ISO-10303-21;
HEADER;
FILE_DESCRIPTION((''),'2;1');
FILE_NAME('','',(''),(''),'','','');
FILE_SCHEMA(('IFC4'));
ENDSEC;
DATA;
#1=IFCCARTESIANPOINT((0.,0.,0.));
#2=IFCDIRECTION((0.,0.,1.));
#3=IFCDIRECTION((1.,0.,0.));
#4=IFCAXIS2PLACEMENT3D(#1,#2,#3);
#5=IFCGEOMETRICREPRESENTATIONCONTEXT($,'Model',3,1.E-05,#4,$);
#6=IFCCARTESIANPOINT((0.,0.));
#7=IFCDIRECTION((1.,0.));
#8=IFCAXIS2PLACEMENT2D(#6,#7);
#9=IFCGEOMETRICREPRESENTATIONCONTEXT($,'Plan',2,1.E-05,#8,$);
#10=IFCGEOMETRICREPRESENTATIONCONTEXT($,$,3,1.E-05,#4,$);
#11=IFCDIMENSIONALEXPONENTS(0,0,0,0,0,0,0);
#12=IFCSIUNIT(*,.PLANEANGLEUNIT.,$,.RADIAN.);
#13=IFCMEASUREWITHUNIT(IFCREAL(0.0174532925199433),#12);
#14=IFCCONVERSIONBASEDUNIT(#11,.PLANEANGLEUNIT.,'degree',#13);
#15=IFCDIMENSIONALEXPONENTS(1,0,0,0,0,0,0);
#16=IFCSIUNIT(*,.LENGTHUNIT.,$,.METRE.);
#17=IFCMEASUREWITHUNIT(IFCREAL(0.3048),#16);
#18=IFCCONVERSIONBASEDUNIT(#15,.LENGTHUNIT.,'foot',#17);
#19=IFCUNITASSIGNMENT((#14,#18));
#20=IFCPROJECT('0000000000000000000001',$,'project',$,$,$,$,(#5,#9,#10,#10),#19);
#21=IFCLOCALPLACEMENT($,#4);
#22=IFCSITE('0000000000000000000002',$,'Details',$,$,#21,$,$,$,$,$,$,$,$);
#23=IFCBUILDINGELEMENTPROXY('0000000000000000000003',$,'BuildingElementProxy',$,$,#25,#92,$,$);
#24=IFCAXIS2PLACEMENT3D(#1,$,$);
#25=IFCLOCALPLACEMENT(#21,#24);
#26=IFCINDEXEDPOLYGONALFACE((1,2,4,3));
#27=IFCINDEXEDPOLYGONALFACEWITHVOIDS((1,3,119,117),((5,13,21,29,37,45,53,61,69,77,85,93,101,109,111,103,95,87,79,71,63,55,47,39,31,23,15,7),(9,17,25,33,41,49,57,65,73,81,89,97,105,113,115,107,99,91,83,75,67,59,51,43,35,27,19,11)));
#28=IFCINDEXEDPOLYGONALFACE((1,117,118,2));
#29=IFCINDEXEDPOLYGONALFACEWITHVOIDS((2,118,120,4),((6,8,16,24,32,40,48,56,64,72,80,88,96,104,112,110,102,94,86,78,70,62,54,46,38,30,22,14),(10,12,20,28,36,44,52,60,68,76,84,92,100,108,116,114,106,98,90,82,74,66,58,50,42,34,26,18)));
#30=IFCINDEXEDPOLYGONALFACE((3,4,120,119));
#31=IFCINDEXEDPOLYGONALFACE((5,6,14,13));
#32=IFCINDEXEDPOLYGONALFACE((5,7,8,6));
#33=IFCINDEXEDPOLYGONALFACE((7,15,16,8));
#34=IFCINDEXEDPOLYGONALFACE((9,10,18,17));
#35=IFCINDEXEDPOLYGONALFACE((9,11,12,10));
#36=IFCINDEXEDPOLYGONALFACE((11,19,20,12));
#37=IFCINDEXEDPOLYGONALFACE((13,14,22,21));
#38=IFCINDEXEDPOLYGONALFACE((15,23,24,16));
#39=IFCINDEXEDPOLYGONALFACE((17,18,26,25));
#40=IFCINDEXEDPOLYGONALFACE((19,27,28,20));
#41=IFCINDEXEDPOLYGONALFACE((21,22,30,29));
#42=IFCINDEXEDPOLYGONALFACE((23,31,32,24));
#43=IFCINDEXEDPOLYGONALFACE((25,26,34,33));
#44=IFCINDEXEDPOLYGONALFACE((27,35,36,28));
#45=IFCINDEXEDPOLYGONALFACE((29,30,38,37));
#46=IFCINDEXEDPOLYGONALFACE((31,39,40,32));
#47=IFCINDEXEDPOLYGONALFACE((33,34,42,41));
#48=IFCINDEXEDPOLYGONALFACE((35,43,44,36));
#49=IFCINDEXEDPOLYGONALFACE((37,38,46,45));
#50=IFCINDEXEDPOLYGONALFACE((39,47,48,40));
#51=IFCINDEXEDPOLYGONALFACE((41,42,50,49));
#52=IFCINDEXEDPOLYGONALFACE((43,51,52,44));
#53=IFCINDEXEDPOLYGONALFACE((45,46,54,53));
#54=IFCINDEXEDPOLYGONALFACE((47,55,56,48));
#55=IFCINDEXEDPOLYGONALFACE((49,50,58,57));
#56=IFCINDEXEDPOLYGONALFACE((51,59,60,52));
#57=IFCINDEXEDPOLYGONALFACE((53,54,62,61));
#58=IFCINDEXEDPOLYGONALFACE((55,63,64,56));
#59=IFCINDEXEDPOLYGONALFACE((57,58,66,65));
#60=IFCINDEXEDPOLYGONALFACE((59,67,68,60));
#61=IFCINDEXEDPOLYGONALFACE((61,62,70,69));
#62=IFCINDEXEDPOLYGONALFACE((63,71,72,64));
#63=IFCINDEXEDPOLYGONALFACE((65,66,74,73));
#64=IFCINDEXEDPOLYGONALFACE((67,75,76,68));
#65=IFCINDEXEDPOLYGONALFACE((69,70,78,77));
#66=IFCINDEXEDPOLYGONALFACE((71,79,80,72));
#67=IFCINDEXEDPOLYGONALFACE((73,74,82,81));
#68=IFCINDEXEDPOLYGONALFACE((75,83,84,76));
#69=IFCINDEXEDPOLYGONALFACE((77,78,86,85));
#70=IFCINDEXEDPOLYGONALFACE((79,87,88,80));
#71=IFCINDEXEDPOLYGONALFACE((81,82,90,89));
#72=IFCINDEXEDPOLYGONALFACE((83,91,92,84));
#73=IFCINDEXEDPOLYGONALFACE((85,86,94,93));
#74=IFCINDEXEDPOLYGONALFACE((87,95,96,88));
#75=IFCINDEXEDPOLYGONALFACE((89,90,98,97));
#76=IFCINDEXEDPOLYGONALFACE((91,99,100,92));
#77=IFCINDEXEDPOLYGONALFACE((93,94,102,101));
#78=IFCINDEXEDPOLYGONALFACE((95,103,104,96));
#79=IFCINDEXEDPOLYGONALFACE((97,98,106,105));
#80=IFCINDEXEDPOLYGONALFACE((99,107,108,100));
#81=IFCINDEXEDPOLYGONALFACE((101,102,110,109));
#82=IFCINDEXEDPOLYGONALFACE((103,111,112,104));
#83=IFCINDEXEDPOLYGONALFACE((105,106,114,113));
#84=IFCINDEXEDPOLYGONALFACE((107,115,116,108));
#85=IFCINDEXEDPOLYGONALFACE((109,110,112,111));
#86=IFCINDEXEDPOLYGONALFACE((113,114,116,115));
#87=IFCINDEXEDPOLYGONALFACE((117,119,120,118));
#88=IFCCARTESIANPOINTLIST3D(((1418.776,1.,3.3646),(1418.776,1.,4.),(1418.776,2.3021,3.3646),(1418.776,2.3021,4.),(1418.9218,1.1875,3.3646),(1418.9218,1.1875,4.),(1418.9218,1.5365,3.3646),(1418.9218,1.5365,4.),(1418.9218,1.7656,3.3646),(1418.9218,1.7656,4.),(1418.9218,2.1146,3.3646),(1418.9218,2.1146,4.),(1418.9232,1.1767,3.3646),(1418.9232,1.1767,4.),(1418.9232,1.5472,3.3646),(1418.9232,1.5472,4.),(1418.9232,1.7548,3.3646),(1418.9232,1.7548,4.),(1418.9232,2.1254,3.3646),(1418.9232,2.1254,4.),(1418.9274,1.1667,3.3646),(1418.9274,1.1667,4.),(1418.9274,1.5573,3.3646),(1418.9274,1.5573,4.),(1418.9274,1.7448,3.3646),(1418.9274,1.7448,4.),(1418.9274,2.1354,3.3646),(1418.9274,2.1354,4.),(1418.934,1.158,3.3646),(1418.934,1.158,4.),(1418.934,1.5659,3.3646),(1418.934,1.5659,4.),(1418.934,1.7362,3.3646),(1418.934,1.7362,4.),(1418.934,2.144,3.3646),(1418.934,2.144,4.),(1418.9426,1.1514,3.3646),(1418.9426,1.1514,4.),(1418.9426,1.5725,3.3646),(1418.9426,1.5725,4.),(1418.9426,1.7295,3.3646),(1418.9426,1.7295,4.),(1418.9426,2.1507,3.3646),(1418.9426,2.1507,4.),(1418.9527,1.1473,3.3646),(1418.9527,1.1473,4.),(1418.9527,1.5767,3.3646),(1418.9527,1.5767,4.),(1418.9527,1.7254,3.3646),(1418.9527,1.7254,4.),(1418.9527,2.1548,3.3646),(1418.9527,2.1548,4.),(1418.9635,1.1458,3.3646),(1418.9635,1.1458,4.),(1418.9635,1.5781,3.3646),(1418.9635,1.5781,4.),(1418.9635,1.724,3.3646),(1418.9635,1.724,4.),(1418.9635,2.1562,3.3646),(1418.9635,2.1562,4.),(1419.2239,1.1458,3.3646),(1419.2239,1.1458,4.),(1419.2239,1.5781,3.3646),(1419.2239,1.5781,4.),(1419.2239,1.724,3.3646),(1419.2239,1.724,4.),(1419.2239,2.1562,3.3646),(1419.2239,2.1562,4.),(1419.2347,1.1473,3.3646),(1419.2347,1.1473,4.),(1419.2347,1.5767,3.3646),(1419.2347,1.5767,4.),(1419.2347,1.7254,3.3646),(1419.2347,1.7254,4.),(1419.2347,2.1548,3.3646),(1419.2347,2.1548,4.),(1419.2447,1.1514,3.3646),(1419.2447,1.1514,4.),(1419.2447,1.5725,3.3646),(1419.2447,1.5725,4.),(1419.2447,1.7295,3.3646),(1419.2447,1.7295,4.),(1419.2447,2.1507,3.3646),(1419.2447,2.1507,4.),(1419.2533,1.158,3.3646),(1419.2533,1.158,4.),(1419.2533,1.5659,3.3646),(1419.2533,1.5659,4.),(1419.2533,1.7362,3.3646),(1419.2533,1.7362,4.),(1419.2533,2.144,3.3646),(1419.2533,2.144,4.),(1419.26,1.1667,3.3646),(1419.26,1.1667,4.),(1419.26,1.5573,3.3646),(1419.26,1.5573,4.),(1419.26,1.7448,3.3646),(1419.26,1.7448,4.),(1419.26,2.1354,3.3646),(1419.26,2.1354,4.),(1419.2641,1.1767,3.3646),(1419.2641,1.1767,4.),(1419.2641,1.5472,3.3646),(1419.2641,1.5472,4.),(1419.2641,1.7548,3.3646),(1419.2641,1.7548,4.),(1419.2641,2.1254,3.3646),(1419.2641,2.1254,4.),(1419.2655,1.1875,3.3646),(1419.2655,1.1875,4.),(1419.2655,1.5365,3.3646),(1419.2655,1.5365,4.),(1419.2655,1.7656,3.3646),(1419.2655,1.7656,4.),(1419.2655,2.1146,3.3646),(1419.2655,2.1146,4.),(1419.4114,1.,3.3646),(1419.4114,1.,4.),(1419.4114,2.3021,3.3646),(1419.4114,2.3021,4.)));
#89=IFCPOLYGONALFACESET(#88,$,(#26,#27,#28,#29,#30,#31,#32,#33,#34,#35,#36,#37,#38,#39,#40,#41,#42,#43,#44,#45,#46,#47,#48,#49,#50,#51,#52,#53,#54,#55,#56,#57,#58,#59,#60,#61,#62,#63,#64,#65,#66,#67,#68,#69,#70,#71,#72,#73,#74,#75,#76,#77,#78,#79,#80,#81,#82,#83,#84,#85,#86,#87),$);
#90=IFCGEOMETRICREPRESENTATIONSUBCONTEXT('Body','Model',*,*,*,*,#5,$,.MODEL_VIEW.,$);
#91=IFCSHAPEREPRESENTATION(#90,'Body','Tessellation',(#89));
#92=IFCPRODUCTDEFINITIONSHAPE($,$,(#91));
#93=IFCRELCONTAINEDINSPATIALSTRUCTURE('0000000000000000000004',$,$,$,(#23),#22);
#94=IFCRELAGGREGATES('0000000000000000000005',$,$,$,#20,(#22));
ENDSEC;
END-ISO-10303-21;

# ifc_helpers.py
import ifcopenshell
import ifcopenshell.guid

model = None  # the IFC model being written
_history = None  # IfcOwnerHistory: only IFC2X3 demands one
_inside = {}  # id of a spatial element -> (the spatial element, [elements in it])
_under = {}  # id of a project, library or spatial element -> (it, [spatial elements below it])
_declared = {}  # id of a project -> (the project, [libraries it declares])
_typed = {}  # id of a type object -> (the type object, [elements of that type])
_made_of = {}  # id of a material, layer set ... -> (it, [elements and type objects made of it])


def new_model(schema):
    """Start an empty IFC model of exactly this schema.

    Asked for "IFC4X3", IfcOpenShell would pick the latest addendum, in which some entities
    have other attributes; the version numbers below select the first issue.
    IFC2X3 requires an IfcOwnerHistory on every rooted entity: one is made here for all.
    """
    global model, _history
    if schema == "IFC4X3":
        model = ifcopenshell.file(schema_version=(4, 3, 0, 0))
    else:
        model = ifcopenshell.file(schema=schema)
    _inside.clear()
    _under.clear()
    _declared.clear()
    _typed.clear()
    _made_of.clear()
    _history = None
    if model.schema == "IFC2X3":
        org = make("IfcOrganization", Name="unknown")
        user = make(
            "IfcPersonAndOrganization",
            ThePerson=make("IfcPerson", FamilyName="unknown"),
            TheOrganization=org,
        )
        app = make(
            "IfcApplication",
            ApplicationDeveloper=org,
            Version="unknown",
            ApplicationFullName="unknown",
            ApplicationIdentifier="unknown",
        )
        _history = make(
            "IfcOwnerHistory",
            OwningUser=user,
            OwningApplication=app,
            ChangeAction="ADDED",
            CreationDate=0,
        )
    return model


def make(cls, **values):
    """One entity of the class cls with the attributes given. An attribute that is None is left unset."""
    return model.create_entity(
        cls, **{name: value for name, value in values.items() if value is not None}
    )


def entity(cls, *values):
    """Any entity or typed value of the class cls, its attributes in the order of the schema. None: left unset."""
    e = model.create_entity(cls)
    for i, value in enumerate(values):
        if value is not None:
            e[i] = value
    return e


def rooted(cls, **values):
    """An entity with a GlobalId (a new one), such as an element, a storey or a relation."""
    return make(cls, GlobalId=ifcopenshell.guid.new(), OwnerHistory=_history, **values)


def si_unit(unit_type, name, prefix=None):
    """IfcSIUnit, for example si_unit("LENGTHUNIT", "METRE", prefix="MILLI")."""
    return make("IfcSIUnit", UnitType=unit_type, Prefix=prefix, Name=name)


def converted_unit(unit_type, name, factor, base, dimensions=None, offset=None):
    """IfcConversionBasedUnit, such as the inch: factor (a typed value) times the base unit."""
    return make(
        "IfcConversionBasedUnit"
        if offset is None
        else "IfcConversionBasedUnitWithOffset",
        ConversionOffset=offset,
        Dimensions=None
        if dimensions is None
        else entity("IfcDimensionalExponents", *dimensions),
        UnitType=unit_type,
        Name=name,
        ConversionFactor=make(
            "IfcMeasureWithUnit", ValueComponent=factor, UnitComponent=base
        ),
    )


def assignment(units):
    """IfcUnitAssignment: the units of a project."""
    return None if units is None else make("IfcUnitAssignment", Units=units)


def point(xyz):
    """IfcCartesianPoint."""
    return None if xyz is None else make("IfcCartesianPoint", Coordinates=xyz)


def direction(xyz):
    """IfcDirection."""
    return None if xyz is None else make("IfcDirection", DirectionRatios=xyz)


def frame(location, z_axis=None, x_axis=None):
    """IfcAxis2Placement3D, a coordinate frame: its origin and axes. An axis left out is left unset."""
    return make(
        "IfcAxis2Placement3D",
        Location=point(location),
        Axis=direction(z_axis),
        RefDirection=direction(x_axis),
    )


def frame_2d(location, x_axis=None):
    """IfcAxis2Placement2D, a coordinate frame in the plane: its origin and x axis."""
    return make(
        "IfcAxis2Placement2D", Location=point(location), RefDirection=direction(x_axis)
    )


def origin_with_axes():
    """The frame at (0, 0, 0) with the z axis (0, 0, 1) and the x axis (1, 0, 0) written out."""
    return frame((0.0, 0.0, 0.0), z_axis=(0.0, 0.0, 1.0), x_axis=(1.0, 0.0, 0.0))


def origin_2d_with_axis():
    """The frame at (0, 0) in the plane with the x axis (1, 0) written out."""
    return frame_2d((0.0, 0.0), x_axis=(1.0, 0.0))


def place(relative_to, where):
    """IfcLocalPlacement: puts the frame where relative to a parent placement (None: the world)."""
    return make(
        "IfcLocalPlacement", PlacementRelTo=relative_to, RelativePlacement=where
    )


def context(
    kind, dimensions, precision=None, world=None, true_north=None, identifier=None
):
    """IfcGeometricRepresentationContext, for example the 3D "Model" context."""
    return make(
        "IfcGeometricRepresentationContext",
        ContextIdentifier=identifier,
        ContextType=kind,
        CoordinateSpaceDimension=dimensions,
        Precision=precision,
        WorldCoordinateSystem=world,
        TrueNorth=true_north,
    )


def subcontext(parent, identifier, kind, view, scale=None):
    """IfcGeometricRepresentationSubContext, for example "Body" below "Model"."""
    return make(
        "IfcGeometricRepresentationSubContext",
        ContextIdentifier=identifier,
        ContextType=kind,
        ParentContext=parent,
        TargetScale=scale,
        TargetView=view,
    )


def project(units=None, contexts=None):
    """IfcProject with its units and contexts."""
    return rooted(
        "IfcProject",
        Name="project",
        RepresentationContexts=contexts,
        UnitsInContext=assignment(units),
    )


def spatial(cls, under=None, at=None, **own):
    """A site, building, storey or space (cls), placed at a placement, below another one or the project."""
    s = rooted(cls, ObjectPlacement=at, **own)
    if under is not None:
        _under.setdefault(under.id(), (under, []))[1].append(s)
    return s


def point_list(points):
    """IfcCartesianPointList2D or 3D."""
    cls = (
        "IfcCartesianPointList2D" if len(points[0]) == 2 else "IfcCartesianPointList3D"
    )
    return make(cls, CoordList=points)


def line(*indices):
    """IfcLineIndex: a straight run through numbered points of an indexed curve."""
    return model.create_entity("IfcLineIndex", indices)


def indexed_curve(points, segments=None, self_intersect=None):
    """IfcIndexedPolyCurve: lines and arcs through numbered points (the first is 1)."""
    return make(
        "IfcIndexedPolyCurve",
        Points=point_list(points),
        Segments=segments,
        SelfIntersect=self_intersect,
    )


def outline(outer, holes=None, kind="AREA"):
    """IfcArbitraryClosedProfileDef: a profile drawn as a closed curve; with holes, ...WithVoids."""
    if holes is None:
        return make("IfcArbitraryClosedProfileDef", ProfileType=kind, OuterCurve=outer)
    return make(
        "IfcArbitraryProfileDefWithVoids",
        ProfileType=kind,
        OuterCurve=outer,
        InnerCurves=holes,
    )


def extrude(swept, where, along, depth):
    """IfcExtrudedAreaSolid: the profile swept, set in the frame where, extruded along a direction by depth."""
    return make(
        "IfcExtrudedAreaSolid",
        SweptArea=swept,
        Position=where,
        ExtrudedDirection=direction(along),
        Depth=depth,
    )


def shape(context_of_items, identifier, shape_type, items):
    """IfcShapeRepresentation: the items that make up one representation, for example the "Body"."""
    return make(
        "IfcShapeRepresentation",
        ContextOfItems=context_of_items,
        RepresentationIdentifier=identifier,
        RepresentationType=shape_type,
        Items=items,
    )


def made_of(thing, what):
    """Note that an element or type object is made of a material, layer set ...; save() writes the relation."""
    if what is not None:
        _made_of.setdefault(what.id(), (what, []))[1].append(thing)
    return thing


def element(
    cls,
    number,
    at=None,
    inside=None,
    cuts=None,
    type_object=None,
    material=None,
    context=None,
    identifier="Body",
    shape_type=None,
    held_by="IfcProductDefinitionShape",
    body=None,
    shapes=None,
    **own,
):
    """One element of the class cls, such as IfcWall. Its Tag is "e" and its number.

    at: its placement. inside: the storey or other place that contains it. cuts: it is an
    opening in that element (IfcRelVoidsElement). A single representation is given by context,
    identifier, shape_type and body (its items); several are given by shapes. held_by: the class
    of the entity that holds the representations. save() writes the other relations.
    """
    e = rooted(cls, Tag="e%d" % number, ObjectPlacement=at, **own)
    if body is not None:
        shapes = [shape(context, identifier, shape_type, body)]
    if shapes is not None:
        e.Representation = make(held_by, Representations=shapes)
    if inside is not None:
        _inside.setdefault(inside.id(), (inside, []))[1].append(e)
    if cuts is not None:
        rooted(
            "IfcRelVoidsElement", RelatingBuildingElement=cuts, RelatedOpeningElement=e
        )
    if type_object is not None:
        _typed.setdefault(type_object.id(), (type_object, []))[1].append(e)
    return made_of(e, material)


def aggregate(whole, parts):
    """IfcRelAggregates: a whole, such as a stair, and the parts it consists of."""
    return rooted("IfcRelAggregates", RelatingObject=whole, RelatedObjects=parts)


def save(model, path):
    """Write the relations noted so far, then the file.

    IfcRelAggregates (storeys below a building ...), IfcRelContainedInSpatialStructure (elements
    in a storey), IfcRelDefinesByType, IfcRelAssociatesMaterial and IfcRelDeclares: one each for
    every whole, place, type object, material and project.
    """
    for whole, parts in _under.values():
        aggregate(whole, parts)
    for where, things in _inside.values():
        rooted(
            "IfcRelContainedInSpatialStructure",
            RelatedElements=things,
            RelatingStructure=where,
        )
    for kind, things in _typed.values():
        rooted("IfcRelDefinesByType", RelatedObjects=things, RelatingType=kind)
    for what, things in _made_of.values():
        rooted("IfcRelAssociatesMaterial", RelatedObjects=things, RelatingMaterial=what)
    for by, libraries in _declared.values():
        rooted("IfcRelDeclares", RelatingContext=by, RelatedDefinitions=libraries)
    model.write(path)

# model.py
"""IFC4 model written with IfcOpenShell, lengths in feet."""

from ifc_helpers import new_model, entity, si_unit, converted_unit, frame, origin_with_axes, origin_2d_with_axis, place, context, subcontext, project, spatial, line, indexed_curve, outline, extrude, element, save


model = new_model("IFC4")

# Units and contexts
model_context = context("Model", 3, precision=1e-05, world=origin_with_axes())
plan_context = context("Plan", 2, precision=1e-05, world=origin_2d_with_axis())
context_of_model = context(None, 3, precision=1e-05, world=origin_with_axes())
body_context = subcontext(model_context, "Body", "Model", "MODEL_VIEW")
ifc_project = project(units=[converted_unit("PLANEANGLEUNIT", "degree", entity("IfcReal", 0.0174532925199433), si_unit("PLANEANGLEUNIT", "RADIAN"), dimensions=[0, 0, 0, 0, 0, 0, 0]), converted_unit("LENGTHUNIT", "foot", entity("IfcReal", 0.3048), si_unit("LENGTHUNIT", "METRE"), dimensions=[1, 0, 0, 0, 0, 0, 0])], contexts=[model_context, plan_context, context_of_model, context_of_model])

# Site
site_placement = place(None, origin_with_axes())
site = spatial("IfcSite", under=ifc_project, at=site_placement, Name="Details")

# Building element proxy
proxy_1_placement = place(site_placement, frame((1419.0936, 2.3021, 3.3646), z_axis=(0.0, 0.0, 1.0), x_axis=(0.0, 1.0, 0.0)))
element("IfcBuildingElementProxy", 1, at=proxy_1_placement, inside=site, Name="BuildingElementProxy", context=body_context, shape_type="SweptSolid", body=[
    extrude(outline(indexed_curve([(-0.3177, -0.651), (0.3177, -0.651), (0.3177, 0.651), (-0.3177, 0.651), (0.1719, -0.1146), (0.1719, -0.4635), (0.1705, -0.4743), (0.1663, -0.4844), (0.1597, -0.493), (0.151, -0.4996), (0.141, -0.5038), (0.1302, -0.5052), (-0.1302, -0.5052), (-0.141, -0.5038), (-0.151, -0.4996), (-0.1597, -0.493), (-0.1663, -0.4844), (-0.1705, -0.4743), (-0.1719, -0.4635), (-0.1719, -0.1146), (-0.1705, -0.1038), (-0.1663, -0.0938), (-0.1597, -0.0851), (-0.151, -0.0785), (-0.141, -0.0743), (-0.1302, -0.0729), (0.1302, -0.0729), (0.141, -0.0743), (0.151, -0.0785), (0.1597, -0.0851), (0.1663, -0.0938), (0.1705, -0.1038), (0.151, 0.0785), (0.141, 0.0743), (0.1302, 0.0729), (-0.1302, 0.0729), (-0.141, 0.0743), (-0.151, 0.0785), (-0.1597, 0.0851), (-0.1663, 0.0937), (-0.1705, 0.1038), (-0.1719, 0.1146), (-0.1719, 0.4635), (-0.1705, 0.4743), (-0.1663, 0.4844), (-0.1597, 0.493), (-0.151, 0.4996), (-0.141, 0.5038), (-0.1302, 0.5052), (0.1302, 0.5052), (0.141, 0.5038), (0.151, 0.4996), (0.1597, 0.493), (0.1663, 0.4844), (0.1705, 0.4743), (0.1719, 0.4635), (0.1719, 0.1146), (0.1705, 0.1038), (0.1663, 0.0937), (0.1597, 0.0851)], segments=[line(4, 3), line(3, 2), line(2, 1), line(1, 4)], self_intersect=False), holes=[indexed_curve([(-0.3177, -0.651), (0.3177, -0.651), (0.3177, 0.651), (-0.3177, 0.651), (0.1719, -0.1146), (0.1719, -0.4635), (0.1705, -0.4743), (0.1663, -0.4844), (0.1597, -0.493), (0.151, -0.4996), (0.141, -0.5038), (0.1302, -0.5052), (-0.1302, -0.5052), (-0.141, -0.5038), (-0.151, -0.4996), (-0.1597, -0.493), (-0.1663, -0.4844), (-0.1705, -0.4743), (-0.1719, -0.4635), (-0.1719, -0.1146), (-0.1705, -0.1038), (-0.1663, -0.0938), (-0.1597, -0.0851), (-0.151, -0.0785), (-0.141, -0.0743), (-0.1302, -0.0729), (0.1302, -0.0729), (0.141, -0.0743), (0.151, -0.0785), (0.1597, -0.0851), (0.1663, -0.0938), (0.1705, -0.1038), (0.151, 0.0785), (0.141, 0.0743), (0.1302, 0.0729), (-0.1302, 0.0729), (-0.141, 0.0743), (-0.151, 0.0785), (-0.1597, 0.0851), (-0.1663, 0.0937), (-0.1705, 0.1038), (-0.1719, 0.1146), (-0.1719, 0.4635), (-0.1705, 0.4743), (-0.1663, 0.4844), (-0.1597, 0.493), (-0.151, 0.4996), (-0.141, 0.5038), (-0.1302, 0.5052), (0.1302, 0.5052), (0.141, 0.5038), (0.151, 0.4996), (0.1597, 0.493), (0.1663, 0.4844), (0.1705, 0.4743), (0.1719, 0.4635), (0.1719, 0.1146), (0.1705, 0.1038), (0.1663, 0.0937), (0.1597, 0.0851)], segments=[line(20, 19), line(19, 18), line(18, 17), line(17, 16), line(16, 15), line(15, 14), line(14, 13), line(13, 12), line(12, 11), line(11, 10), line(10, 9), line(9, 8), line(8, 7), line(7, 6), line(6, 5), line(5, 32), line(32, 31), line(31, 30), line(30, 29), line(29, 28), line(28, 27), line(27, 26), line(26, 25), line(25, 24), line(24, 23), line(23, 22), line(22, 21), line(21, 20)], self_intersect=False), indexed_curve([(-0.3177, -0.651), (0.3177, -0.651), (0.3177, 0.651), (-0.3177, 0.651), (0.1719, -0.1146), (0.1719, -0.4635), (0.1705, -0.4743), (0.1663, -0.4844), (0.1597, -0.493), (0.151, -0.4996), (0.141, -0.5038), (0.1302, -0.5052), (-0.1302, -0.5052), (-0.141, -0.5038), (-0.151, -0.4996), (-0.1597, -0.493), (-0.1663, -0.4844), (-0.1705, -0.4743), (-0.1719, -0.4635), (-0.1719, -0.1146), (-0.1705, -0.1038), (-0.1663, -0.0938), (-0.1597, -0.0851), (-0.151, -0.0785), (-0.141, -0.0743), (-0.1302, -0.0729), (0.1302, -0.0729), (0.141, -0.0743), (0.151, -0.0785), (0.1597, -0.0851), (0.1663, -0.0938), (0.1705, -0.1038), (0.151, 0.0785), (0.141, 0.0743), (0.1302, 0.0729), (-0.1302, 0.0729), (-0.141, 0.0743), (-0.151, 0.0785), (-0.1597, 0.0851), (-0.1663, 0.0937), (-0.1705, 0.1038), (-0.1719, 0.1146), (-0.1719, 0.4635), (-0.1705, 0.4743), (-0.1663, 0.4844), (-0.1597, 0.493), (-0.151, 0.4996), (-0.141, 0.5038), (-0.1302, 0.5052), (0.1302, 0.5052), (0.141, 0.5038), (0.151, 0.4996), (0.1597, 0.493), (0.1663, 0.4844), (0.1705, 0.4743), (0.1719, 0.4635), (0.1719, 0.1146), (0.1705, 0.1038), (0.1663, 0.0937), (0.1597, 0.0851)], segments=[line(44, 43), line(43, 42), line(42, 41), line(41, 40), line(40, 39), line(39, 38), line(38, 37), line(37, 36), line(36, 35), line(35, 34), line(34, 33), line(33, 60), line(60, 59), line(59, 58), line(58, 57), line(57, 56), line(56, 55), line(55, 54), line(54, 53), line(53, 52), line(52, 51), line(51, 50), line(50, 49), line(49, 48), line(48, 47), line(47, 46), line(46, 45), line(45, 44)], self_intersect=False)]), frame((-0.651, 0.0, 0.0), z_axis=(0.0, 0.0, 1.0), x_axis=(0.0, -1.0, 0.0)), (0.0, 0.0, 1.0), 0.6354),
])

save(model, "model.ifc")
